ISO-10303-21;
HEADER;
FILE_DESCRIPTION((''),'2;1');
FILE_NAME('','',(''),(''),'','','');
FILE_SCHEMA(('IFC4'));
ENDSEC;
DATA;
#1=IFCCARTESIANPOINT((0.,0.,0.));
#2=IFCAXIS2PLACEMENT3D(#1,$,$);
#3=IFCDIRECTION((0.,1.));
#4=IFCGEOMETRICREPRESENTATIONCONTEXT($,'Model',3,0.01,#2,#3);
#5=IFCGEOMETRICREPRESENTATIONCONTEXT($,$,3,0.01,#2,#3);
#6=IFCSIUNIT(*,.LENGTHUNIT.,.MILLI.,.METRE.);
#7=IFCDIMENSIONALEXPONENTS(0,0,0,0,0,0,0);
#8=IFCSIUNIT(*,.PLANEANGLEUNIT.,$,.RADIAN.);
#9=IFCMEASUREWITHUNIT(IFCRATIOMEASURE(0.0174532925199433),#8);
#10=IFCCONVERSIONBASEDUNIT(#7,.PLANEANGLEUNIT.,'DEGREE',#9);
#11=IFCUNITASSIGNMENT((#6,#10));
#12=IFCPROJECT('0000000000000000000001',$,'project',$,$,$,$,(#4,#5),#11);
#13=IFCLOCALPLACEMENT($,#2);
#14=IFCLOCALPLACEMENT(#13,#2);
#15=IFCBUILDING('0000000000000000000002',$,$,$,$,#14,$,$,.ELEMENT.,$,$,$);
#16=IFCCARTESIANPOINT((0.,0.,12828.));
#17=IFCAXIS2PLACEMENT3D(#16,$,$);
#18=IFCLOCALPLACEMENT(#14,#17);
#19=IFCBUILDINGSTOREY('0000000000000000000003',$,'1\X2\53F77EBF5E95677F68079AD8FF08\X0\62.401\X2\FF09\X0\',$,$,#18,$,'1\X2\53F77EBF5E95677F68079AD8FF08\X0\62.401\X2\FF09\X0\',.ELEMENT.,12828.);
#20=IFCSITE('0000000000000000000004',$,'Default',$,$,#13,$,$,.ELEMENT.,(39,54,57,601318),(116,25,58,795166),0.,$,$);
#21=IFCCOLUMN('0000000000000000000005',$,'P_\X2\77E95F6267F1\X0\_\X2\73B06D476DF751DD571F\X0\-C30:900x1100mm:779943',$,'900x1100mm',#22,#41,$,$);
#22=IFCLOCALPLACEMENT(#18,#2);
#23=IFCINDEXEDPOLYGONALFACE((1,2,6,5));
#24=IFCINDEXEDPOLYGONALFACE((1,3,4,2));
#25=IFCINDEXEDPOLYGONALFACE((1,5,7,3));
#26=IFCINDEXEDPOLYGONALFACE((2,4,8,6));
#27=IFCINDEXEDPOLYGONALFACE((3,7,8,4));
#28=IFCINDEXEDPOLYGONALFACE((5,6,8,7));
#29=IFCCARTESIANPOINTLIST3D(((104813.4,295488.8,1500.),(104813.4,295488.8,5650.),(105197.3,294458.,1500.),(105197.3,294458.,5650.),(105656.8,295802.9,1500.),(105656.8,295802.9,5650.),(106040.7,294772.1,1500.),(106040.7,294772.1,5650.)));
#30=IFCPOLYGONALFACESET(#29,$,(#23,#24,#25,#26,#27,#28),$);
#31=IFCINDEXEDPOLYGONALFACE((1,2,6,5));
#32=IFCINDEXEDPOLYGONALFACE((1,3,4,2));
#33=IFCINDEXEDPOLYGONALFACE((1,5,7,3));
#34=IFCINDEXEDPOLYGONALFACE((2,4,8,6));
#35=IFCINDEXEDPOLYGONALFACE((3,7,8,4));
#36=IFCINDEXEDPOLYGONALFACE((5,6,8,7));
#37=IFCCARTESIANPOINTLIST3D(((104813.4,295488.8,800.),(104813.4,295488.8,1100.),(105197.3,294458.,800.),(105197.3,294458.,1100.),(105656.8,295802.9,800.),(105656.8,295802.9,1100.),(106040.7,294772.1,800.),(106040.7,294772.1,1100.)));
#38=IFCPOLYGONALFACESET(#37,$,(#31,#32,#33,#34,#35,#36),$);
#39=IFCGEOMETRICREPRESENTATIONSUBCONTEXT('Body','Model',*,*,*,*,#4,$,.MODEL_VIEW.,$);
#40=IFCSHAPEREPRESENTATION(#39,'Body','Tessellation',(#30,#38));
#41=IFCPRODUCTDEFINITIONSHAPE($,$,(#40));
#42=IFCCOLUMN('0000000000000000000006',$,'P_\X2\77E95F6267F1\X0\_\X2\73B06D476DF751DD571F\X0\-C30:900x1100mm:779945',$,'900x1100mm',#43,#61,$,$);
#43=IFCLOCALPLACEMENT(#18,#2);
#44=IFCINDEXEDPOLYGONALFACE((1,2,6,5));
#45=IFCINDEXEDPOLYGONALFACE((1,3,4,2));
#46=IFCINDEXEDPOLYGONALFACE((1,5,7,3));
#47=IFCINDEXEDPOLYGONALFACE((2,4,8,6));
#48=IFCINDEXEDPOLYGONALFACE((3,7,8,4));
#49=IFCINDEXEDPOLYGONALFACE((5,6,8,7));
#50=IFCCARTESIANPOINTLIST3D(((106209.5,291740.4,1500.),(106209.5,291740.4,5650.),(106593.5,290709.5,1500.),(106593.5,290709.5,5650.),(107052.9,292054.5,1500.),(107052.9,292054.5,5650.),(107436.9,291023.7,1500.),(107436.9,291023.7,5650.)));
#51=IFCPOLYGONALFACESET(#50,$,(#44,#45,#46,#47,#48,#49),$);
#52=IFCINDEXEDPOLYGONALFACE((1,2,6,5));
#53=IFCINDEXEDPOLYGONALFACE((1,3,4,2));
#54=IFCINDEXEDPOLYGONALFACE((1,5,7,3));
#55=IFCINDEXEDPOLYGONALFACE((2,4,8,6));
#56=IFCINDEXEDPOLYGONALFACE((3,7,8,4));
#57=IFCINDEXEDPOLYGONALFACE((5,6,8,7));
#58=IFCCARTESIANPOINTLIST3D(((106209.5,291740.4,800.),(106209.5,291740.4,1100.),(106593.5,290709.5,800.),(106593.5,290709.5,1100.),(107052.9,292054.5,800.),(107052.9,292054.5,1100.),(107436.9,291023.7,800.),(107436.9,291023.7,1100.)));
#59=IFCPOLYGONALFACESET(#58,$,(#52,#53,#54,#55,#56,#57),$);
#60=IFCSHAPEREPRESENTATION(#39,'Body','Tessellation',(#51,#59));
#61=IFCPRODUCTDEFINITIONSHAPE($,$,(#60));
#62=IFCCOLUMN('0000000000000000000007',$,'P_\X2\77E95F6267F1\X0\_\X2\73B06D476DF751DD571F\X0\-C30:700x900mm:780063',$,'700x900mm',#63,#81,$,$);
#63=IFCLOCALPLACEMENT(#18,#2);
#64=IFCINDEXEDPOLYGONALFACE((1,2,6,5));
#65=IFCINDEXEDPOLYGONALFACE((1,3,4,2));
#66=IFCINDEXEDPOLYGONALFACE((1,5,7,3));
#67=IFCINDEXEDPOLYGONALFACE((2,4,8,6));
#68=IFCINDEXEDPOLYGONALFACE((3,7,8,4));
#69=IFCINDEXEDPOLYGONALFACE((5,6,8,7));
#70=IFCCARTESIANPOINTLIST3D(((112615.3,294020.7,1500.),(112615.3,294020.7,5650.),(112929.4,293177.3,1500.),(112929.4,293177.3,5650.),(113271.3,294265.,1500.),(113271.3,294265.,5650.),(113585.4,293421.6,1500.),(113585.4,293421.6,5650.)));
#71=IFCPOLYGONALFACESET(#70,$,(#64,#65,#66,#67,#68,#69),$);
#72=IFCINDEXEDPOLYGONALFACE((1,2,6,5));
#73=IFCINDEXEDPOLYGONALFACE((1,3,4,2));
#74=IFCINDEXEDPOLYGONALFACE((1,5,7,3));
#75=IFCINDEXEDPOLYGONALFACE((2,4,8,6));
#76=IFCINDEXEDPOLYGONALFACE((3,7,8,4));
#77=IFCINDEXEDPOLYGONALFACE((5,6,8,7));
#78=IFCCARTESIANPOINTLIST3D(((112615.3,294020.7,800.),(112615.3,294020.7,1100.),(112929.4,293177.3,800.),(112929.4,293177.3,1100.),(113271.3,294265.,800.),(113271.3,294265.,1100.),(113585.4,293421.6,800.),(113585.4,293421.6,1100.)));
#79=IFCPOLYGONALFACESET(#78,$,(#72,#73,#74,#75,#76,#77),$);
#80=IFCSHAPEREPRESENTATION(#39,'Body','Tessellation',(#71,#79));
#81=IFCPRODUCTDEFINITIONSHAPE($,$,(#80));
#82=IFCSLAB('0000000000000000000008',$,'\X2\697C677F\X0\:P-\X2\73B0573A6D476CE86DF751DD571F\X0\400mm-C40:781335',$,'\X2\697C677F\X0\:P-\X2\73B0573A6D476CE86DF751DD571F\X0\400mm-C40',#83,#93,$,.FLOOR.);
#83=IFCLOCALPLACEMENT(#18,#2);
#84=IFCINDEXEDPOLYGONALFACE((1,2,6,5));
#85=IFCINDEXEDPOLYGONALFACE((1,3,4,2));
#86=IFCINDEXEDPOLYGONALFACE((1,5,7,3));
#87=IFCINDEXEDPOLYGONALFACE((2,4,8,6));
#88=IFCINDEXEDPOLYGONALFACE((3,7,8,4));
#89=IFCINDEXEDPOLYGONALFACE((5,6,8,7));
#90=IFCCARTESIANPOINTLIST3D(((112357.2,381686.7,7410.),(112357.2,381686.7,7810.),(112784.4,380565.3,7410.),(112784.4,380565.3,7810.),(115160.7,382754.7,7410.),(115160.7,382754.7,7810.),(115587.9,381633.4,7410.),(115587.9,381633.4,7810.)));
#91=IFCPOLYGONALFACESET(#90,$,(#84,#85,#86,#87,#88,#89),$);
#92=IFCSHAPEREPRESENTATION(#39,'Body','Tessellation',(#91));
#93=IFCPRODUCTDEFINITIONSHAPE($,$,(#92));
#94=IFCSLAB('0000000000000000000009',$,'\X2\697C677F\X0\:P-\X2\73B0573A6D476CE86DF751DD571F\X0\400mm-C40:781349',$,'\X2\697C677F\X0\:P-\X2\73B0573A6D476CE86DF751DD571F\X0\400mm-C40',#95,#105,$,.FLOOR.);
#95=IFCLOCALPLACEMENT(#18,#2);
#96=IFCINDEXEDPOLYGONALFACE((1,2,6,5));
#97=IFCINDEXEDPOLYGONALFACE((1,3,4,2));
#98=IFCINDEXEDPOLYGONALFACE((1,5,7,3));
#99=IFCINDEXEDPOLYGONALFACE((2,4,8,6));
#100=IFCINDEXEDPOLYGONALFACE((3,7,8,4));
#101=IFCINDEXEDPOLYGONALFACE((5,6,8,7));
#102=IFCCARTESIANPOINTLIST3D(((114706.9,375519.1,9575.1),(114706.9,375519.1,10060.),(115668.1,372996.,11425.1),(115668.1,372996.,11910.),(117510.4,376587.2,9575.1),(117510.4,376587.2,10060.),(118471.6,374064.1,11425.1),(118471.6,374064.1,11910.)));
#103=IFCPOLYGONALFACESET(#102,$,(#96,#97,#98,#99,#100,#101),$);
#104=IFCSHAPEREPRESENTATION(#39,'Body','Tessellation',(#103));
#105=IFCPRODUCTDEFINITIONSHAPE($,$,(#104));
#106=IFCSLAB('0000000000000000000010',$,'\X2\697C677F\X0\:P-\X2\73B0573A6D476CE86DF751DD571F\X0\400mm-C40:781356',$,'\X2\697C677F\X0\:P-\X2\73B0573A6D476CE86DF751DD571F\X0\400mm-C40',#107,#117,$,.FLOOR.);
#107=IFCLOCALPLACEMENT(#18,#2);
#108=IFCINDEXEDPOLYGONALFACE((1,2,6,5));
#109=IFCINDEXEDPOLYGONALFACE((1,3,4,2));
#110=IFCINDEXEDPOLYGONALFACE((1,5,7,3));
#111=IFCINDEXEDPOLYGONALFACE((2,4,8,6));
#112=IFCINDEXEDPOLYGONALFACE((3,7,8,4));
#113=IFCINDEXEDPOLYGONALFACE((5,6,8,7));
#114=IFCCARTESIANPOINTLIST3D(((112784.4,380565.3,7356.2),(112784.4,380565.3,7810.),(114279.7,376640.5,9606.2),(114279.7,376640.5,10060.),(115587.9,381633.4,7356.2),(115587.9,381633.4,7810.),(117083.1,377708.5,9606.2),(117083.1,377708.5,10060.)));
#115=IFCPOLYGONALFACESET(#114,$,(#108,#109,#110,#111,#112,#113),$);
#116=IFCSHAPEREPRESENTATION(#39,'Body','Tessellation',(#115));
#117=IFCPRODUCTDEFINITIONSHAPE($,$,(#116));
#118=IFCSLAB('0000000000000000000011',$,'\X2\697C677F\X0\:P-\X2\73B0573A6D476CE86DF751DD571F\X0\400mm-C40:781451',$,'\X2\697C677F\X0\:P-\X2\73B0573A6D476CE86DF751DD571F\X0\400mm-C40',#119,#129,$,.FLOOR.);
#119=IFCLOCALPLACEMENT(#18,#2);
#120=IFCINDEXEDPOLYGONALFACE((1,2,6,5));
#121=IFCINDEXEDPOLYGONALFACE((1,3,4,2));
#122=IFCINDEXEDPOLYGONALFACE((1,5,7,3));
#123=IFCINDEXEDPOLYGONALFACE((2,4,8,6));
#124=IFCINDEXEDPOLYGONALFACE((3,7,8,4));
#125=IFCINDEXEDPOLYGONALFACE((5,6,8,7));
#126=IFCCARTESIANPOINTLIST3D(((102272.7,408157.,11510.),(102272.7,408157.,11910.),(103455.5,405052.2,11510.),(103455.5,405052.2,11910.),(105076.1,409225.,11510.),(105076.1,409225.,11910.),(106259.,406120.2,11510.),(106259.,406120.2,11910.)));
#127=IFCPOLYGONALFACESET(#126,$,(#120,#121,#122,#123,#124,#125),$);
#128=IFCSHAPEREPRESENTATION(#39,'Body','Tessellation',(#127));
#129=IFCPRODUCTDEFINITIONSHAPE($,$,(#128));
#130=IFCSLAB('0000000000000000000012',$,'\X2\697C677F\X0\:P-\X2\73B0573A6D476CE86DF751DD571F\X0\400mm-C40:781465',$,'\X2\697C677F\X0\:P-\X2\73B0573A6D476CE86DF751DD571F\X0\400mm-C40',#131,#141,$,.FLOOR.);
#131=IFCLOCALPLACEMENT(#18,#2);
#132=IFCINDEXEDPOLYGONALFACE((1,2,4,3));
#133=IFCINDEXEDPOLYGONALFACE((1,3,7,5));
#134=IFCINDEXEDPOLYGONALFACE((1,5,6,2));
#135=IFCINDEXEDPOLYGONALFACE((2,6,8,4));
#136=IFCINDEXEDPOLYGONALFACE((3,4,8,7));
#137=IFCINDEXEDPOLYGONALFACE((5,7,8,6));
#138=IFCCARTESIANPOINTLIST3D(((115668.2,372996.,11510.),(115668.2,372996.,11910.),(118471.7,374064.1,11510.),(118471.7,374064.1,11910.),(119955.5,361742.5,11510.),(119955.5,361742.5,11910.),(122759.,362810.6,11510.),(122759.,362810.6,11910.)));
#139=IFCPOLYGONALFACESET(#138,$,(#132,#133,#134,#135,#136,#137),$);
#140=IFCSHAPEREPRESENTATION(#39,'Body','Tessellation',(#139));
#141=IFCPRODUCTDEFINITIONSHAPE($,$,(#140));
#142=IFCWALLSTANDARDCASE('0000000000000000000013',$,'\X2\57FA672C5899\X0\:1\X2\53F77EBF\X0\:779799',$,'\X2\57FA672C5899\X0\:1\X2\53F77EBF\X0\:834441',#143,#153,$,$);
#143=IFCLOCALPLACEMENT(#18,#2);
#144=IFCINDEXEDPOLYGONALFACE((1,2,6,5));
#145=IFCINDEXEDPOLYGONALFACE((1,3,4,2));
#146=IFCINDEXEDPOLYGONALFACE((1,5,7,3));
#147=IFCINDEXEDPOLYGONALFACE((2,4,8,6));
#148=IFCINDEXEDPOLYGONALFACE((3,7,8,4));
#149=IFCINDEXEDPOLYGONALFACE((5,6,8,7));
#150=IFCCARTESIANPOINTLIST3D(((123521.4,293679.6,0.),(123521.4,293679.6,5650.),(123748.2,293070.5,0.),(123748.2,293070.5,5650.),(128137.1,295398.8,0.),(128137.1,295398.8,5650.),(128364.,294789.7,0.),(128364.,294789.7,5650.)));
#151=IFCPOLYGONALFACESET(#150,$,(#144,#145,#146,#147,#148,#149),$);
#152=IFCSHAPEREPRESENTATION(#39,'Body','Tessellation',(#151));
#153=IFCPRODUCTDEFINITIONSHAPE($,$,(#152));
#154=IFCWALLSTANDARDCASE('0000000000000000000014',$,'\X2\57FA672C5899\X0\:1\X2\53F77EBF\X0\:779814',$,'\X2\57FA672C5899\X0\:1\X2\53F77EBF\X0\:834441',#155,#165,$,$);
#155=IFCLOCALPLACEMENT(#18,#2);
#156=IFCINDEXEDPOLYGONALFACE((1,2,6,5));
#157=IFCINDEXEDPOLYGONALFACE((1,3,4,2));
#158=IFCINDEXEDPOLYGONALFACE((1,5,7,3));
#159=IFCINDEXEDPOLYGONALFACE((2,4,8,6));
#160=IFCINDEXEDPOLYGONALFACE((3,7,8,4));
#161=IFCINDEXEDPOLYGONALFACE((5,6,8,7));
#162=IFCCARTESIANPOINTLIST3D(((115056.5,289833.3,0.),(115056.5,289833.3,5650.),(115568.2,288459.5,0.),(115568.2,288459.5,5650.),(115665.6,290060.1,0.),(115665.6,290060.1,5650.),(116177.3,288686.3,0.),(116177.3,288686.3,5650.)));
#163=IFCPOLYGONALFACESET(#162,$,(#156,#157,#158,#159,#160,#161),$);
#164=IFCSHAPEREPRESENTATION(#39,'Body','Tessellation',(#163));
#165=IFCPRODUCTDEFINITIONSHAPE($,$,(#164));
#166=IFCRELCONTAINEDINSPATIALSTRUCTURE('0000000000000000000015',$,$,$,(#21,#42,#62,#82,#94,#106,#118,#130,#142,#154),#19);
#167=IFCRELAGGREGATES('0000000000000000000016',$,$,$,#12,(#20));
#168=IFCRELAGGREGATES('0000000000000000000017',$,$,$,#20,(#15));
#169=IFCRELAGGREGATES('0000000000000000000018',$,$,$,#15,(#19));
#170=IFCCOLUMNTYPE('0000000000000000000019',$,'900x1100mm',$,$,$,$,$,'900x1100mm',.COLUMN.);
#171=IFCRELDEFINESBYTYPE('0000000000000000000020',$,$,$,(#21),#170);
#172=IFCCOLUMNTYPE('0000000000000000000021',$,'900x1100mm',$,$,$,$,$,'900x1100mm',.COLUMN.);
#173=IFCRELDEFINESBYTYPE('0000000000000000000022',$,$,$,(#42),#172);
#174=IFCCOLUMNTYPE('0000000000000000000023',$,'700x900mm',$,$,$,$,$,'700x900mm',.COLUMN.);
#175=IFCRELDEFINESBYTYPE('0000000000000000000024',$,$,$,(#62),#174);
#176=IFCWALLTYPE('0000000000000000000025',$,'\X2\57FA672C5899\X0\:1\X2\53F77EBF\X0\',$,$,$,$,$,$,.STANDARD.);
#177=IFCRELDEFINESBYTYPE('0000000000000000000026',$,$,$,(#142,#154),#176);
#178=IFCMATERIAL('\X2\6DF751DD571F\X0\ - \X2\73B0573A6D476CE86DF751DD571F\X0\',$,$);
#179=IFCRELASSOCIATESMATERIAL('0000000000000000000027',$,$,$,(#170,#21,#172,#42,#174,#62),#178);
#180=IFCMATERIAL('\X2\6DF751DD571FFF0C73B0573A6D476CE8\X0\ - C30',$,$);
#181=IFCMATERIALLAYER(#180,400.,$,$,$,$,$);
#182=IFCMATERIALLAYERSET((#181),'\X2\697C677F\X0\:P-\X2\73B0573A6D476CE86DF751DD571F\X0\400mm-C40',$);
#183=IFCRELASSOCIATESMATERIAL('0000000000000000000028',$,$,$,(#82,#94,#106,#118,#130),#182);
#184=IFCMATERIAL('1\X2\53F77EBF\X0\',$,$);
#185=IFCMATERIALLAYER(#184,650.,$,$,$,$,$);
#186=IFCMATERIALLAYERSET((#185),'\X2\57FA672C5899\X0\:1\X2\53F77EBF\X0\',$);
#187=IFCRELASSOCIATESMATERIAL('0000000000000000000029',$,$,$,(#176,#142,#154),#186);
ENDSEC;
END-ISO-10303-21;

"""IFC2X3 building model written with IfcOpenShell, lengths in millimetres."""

from ifc_helpers import new_model, entity, si_unit, converted_unit, direction, frame, frame_2d, origin, origin_2d_with_axis, place, context, subcontext, project, spatial, polyline, rectangle, outline, extrude, clip, halfspace, bounded_halfspace, source, transform, mapped, material, layer, layer_set, layer_usage, type_object, type_shapes, element, save


model = new_model("IFC2X3")

# Units and contexts
model_context = context("Model", 3, precision=0.01, world=origin(), true_north=direction((0.0, 1.0)))
context_of_model = context(None, 3, precision=0.01, world=origin(), true_north=direction((0.0, 1.0)))
body_context = subcontext(model_context, "Body", "Model", "MODEL_VIEW")
ifc_project = project(units=[si_unit("LENGTHUNIT", "METRE", prefix="MILLI"), converted_unit("PLANEANGLEUNIT", "DEGREE", entity("IfcRatioMeasure", 0.0174532925199433), si_unit("PLANEANGLEUNIT", "RADIAN"), dimensions=[0, 0, 0, 0, 0, 0, 0])], contexts=[model_context, context_of_model])

# Site, building, storey
site_placement = place(None, origin())
site = spatial("IfcSite", under=ifc_project, at=site_placement, Name="Default", CompositionType="ELEMENT", RefLatitude=(39, 54, 57, 601318), RefLongitude=(116, 25, 58, 795166), RefElevation=0.0)
building_placement = place(site_placement, origin())
building = spatial("IfcBuilding", under=site, at=building_placement, CompositionType="ELEMENT")
storey_placement = place(building_placement, frame((0.0, 0.0, 12828.0)))
storey = spatial("IfcBuildingStorey", under=building, at=storey_placement, Name="1号线底板标高（62.401）", LongName="1号线底板标高（62.401）", CompositionType="ELEMENT", Elevation=12828.0)

# Columns
ifc_material_1 = material(Name="混凝土 - 现场浇注混凝土")
column_type_1 = type_object("IfcColumnType", Name="900x1100mm", ElementType="900x1100mm", PredefinedType="COLUMN", material=ifc_material_1)
shared_shape_1 = source(origin(), body_context, "Body", "SweptSolid", [
    extrude(rectangle(XDim=900.0, YDim=1100.0, at=frame_2d((0.0, 0.0), x_axis=(1.0, 0.0))), frame((613.7, 672.5, 700.0), z_axis=(0.0, 0.0, 1.0), x_axis=(-0.937112, -0.349028, 0.0)), (0.0, 0.0, 1.0), 4150.0),
    extrude(rectangle(XDim=900.0, YDim=1100.0, at=frame_2d((0.0, 0.0), x_axis=(1.0, 0.0))), frame((613.7, 672.5, 0.0), z_axis=(0.0, 0.0, 1.0), x_axis=(-0.937112, -0.349028, 0.0)), (0.0, 0.0, 1.0), 300.0),
])
type_shapes(column_type_1, [shared_shape_1])
column_1_placement = place(storey_placement, frame((104813.4, 294458.0, 800.0)))
element("IfcColumn", 1, at=column_1_placement, inside=storey, type_object=column_type_1, material=ifc_material_1, Name="P_矩形柱_现浇混凝土-C30:900x1100mm:779943", ObjectType="900x1100mm", context=body_context, shape_type="MappedRepresentation", body=[
    mapped(shared_shape_1, transform((0.0, 0.0, 0.0), scale=1.0)),
])
column_type_2 = type_object("IfcColumnType", Name="900x1100mm", ElementType="900x1100mm", PredefinedType="COLUMN", material=ifc_material_1)
shared_shape_2 = source(origin(), body_context, "Body", "SweptSolid", [
    extrude(rectangle(XDim=900.0, YDim=1100.0, at=frame_2d((0.0, 0.0), x_axis=(1.0, 0.0))), frame((613.7, 672.5, 700.0), z_axis=(0.0, 0.0, 1.0), x_axis=(-0.937112, -0.349028, 0.0)), (0.0, 0.0, 1.0), 4150.0),
    extrude(rectangle(XDim=900.0, YDim=1100.0, at=frame_2d((0.0, 0.0), x_axis=(1.0, 0.0))), frame((613.7, 672.5, 0.0), z_axis=(0.0, 0.0, 1.0), x_axis=(-0.937112, -0.349028, 0.0)), (0.0, 0.0, 1.0), 300.0),
])
type_shapes(column_type_2, [shared_shape_2])
column_2_placement = place(storey_placement, frame((106209.5, 290709.5, 800.0)))
element("IfcColumn", 2, at=column_2_placement, inside=storey, type_object=column_type_2, material=ifc_material_1, Name="P_矩形柱_现浇混凝土-C30:900x1100mm:779945", ObjectType="900x1100mm", context=body_context, shape_type="MappedRepresentation", body=[
    mapped(shared_shape_2, transform((0.0, 0.0, 0.0), scale=1.0)),
])
column_type_3 = type_object("IfcColumnType", Name="700x900mm", ElementType="700x900mm", PredefinedType="COLUMN", material=ifc_material_1)
shared_shape_3 = source(origin(), body_context, "Body", "SweptSolid", [
    extrude(rectangle(XDim=700.0, YDim=900.0, at=frame_2d((0.0, 0.0), x_axis=(1.0, 0.0))), frame((485.1, 543.9, 700.0), z_axis=(0.0, 0.0, 1.0), x_axis=(-0.937112, -0.349028, 0.0)), (0.0, 0.0, 1.0), 4150.0),
    extrude(rectangle(XDim=700.0, YDim=900.0, at=frame_2d((0.0, 0.0), x_axis=(1.0, 0.0))), frame((485.1, 543.9, 0.0), z_axis=(0.0, 0.0, 1.0), x_axis=(-0.937112, -0.349028, 0.0)), (0.0, 0.0, 1.0), 300.0),
])
type_shapes(column_type_3, [shared_shape_3])
column_3_placement = place(storey_placement, frame((112615.3, 293177.3, 800.0)))
element("IfcColumn", 3, at=column_3_placement, inside=storey, type_object=column_type_3, material=ifc_material_1, Name="P_矩形柱_现浇混凝土-C30:700x900mm:780063", ObjectType="700x900mm", context=body_context, shape_type="MappedRepresentation", body=[
    mapped(shared_shape_3, transform((0.0, 0.0, 0.0), scale=1.0)),
])

# Slabs
ifc_material_2 = material(Name="混凝土，现场浇注 - C30")
ifc_layer_1 = layer(ifc_material_2, 400.0)
ifc_layer_set_1 = layer_set([ifc_layer_1], Name="楼板:P-现场浇注混凝土400mm-C40")
ifc_layer_usage_1 = layer_usage(ifc_layer_set_1, "AXIS3", "POSITIVE", 0.0)
slab_1_placement = place(storey_placement, origin())
element("IfcSlab", 4, at=slab_1_placement, inside=storey, material=ifc_layer_usage_1, Name="楼板:P-现场浇注混凝土400mm-C40:781335", ObjectType="楼板:P-现场浇注混凝土400mm-C40", PredefinedType="FLOOR", context=body_context, shape_type="SweptSolid", body=[
    extrude(rectangle(XDim=3000.0, YDim=1200.0, at=origin_2d_with_axis()), frame((113972.6, 381660.0, 7810.0), z_axis=(0.0, 0.0, -1.0), x_axis=(0.934481, 0.356012, 0.0)), (0.0, 0.0, 1.0), 400.0),
])
ifc_layer_usage_2 = layer_usage(ifc_layer_set_1, "AXIS3", "POSITIVE", 0.0)
slab_2_placement = place(storey_placement, origin())
element("IfcSlab", 5, at=slab_2_placement, inside=storey, material=ifc_layer_usage_2, Name="楼板:P-现场浇注混凝土400mm-C40:781349", ObjectType="楼板:P-现场浇注混凝土400mm-C40", PredefinedType="FLOOR", context=body_context, shape_type="Clipping", body=[
    clip(clip(extrude(rectangle(XDim=3273.0, YDim=3000.0, at=frame_2d((0.0, 0.0), x_axis=(1.0, 0.0))), frame((116589.2, 374791.6, 10985.0), z_axis=(0.201229, -0.528198, -0.824932), x_axis=(0.293686, -0.770884, 0.565231)), (-0.565231, 0.0, 0.824932), 587.8), halfspace(frame((117069.9, 373530.0, 11910.0), z_axis=(-0.201229, 0.528198, 0.824932), x_axis=(0.979544, 0.108509, 0.169467)), False)), halfspace(frame((117069.9, 373530.0, 11425.1), z_axis=(0.201229, -0.528198, -0.824932), x_axis=(0.979544, 0.108509, 0.169467)), False)),
])
ifc_layer_usage_3 = layer_usage(ifc_layer_set_1, "AXIS3", "POSITIVE", 0.0)
slab_3_placement = place(storey_placement, origin())
element("IfcSlab", 6, at=slab_3_placement, inside=storey, material=ifc_layer_usage_3, Name="楼板:P-现场浇注混凝土400mm-C40:781356", ObjectType="楼板:P-现场浇注混凝土400mm-C40", PredefinedType="FLOOR", context=body_context, shape_type="Clipping", body=[
    clip(clip(extrude(rectangle(XDim=4764.7, YDim=3000.0, at=frame_2d((0.0, 0.0), x_axis=(1.0, 0.0))), frame((114933.8, 379136.9, 8935.0), z_axis=(0.168116, -0.441282, -0.88148), x_axis=(0.313817, -0.823727, 0.472221)), (-0.472221, 0.0, 0.88148), 514.8), halfspace(frame((115681.4, 377174.5, 10060.0), z_axis=(-0.168116, 0.441282, 0.88148), x_axis=(0.985767, 0.075258, 0.150331)), False)), halfspace(frame((115681.4, 377174.5, 9606.2), z_axis=(0.168116, -0.441282, -0.88148), x_axis=(0.985767, 0.075258, 0.150331)), False)),
])
ifc_layer_usage_4 = layer_usage(ifc_layer_set_1, "AXIS3", "POSITIVE", 0.0)
slab_4_placement = place(storey_placement, origin())
element("IfcSlab", 7, at=slab_4_placement, inside=storey, material=ifc_layer_usage_4, Name="楼板:P-现场浇注混凝土400mm-C40:781451", ObjectType="楼板:P-现场浇注混凝土400mm-C40", PredefinedType="FLOOR", context=body_context, shape_type="SweptSolid", body=[
    extrude(rectangle(XDim=3322.5, YDim=3000.0, at=frame_2d((0.0, 0.0), x_axis=(1.0, 0.0))), frame((104265.8, 407138.6, 11910.0), z_axis=(0.0, 0.0, -1.0), x_axis=(0.356017, -0.93448, 0.0)), (0.0, 0.0, 1.0), 400.0),
])
ifc_layer_usage_5 = layer_usage(ifc_layer_set_1, "AXIS3", "POSITIVE", 0.0)
slab_5_placement = place(storey_placement, origin())
element("IfcSlab", 8, at=slab_5_placement, inside=storey, material=ifc_layer_usage_5, Name="楼板:P-现场浇注混凝土400mm-C40:781465", ObjectType="楼板:P-现场浇注混凝土400mm-C40", PredefinedType="FLOOR", context=body_context, shape_type="SweptSolid", body=[
    extrude(outline(polyline([(-6021.2, -1500.0), (6021.3, -1500.0), (6021.3, 1500.0), (-6021.3, 1500.0), (-6021.2, -1500.0)])), frame((119213.6, 367903.3, 11910.0), z_axis=(0.0, 0.0, -1.0), x_axis=(0.356017, -0.93448, 0.0)), (0.0, 0.0, 1.0), 400.0),
])

# Walls
ifc_material_3 = material(Name="1号线")
ifc_layer_2 = layer(ifc_material_3, 650.0)
ifc_layer_set_2 = layer_set([ifc_layer_2], Name="基本墙:1号线")
ifc_layer_usage_6 = layer_usage(ifc_layer_set_2, "AXIS2", "NEGATIVE", 325.0)
wall_type_1 = type_object("IfcWallType", Name="基本墙:1号线", PredefinedType="STANDARD", material=ifc_layer_set_2)
wall_1_placement = place(storey_placement, frame((128250.6, 295094.2, 0.0), z_axis=(0.0, 0.0, 1.0), x_axis=(-0.937112, -0.349028, 0.0)))
element("IfcWallStandardCase", 9, at=wall_1_placement, inside=storey, type_object=wall_type_1, material=ifc_layer_usage_6, Name="基本墙:1号线:779799", ObjectType="基本墙:1号线:834441", context=body_context, shape_type="Clipping", body=[
    clip(extrude(rectangle(XDim=4925.5, YDim=650.0, at=frame_2d((2462.8, 0.0), x_axis=(-1.0, 0.0))), origin(), (0.0, 0.0, 1.0), 5650.0), bounded_halfspace(frame((0.0, -325.0, 5650.0), z_axis=(0.0, 0.0, -1.0), x_axis=(-1.0, 0.0, 0.0)), True, frame((0.0, -325.0, 5650.0)), polyline([(0.0, 0.0), (3725.5, 0.0), (4125.5, 0.0), (4925.5, 0.0), (4925.5, 650.0), (4225.5, 650.0), (3863.0, 650.0), (0.0, 650.0), (0.0, 0.0)]))),
])
ifc_layer_usage_7 = layer_usage(ifc_layer_set_2, "AXIS2", "NEGATIVE", 325.0)
wall_2_placement = place(storey_placement, frame((115361.1, 289946.7, 0.0), z_axis=(0.0, 0.0, 1.0), x_axis=(0.349028, -0.937112, 0.0)))
element("IfcWallStandardCase", 10, at=wall_2_placement, inside=storey, type_object=wall_type_1, material=ifc_layer_usage_7, Name="基本墙:1号线:779814", ObjectType="基本墙:1号线:834441", context=body_context, shape_type="Clipping", body=[
    clip(extrude(rectangle(XDim=1466.0, YDim=650.0, at=frame_2d((733.0, 0.0), x_axis=(-1.0, 0.0))), origin(), (0.0, 0.0, 1.0), 5650.0), bounded_halfspace(frame((0.0, -325.0, 5650.0), z_axis=(0.0, 0.0, -1.0), x_axis=(0.0, 1.0, 0.0)), True, frame((0.0, -325.0, 5650.0)), polyline([(0.0, 0.0), (487.5, 0.0), (1466.0, 0.0), (1466.0, 650.0), (0.0, 650.0), (0.0, 0.0)]))),
])

save(model, "model.ifc")
